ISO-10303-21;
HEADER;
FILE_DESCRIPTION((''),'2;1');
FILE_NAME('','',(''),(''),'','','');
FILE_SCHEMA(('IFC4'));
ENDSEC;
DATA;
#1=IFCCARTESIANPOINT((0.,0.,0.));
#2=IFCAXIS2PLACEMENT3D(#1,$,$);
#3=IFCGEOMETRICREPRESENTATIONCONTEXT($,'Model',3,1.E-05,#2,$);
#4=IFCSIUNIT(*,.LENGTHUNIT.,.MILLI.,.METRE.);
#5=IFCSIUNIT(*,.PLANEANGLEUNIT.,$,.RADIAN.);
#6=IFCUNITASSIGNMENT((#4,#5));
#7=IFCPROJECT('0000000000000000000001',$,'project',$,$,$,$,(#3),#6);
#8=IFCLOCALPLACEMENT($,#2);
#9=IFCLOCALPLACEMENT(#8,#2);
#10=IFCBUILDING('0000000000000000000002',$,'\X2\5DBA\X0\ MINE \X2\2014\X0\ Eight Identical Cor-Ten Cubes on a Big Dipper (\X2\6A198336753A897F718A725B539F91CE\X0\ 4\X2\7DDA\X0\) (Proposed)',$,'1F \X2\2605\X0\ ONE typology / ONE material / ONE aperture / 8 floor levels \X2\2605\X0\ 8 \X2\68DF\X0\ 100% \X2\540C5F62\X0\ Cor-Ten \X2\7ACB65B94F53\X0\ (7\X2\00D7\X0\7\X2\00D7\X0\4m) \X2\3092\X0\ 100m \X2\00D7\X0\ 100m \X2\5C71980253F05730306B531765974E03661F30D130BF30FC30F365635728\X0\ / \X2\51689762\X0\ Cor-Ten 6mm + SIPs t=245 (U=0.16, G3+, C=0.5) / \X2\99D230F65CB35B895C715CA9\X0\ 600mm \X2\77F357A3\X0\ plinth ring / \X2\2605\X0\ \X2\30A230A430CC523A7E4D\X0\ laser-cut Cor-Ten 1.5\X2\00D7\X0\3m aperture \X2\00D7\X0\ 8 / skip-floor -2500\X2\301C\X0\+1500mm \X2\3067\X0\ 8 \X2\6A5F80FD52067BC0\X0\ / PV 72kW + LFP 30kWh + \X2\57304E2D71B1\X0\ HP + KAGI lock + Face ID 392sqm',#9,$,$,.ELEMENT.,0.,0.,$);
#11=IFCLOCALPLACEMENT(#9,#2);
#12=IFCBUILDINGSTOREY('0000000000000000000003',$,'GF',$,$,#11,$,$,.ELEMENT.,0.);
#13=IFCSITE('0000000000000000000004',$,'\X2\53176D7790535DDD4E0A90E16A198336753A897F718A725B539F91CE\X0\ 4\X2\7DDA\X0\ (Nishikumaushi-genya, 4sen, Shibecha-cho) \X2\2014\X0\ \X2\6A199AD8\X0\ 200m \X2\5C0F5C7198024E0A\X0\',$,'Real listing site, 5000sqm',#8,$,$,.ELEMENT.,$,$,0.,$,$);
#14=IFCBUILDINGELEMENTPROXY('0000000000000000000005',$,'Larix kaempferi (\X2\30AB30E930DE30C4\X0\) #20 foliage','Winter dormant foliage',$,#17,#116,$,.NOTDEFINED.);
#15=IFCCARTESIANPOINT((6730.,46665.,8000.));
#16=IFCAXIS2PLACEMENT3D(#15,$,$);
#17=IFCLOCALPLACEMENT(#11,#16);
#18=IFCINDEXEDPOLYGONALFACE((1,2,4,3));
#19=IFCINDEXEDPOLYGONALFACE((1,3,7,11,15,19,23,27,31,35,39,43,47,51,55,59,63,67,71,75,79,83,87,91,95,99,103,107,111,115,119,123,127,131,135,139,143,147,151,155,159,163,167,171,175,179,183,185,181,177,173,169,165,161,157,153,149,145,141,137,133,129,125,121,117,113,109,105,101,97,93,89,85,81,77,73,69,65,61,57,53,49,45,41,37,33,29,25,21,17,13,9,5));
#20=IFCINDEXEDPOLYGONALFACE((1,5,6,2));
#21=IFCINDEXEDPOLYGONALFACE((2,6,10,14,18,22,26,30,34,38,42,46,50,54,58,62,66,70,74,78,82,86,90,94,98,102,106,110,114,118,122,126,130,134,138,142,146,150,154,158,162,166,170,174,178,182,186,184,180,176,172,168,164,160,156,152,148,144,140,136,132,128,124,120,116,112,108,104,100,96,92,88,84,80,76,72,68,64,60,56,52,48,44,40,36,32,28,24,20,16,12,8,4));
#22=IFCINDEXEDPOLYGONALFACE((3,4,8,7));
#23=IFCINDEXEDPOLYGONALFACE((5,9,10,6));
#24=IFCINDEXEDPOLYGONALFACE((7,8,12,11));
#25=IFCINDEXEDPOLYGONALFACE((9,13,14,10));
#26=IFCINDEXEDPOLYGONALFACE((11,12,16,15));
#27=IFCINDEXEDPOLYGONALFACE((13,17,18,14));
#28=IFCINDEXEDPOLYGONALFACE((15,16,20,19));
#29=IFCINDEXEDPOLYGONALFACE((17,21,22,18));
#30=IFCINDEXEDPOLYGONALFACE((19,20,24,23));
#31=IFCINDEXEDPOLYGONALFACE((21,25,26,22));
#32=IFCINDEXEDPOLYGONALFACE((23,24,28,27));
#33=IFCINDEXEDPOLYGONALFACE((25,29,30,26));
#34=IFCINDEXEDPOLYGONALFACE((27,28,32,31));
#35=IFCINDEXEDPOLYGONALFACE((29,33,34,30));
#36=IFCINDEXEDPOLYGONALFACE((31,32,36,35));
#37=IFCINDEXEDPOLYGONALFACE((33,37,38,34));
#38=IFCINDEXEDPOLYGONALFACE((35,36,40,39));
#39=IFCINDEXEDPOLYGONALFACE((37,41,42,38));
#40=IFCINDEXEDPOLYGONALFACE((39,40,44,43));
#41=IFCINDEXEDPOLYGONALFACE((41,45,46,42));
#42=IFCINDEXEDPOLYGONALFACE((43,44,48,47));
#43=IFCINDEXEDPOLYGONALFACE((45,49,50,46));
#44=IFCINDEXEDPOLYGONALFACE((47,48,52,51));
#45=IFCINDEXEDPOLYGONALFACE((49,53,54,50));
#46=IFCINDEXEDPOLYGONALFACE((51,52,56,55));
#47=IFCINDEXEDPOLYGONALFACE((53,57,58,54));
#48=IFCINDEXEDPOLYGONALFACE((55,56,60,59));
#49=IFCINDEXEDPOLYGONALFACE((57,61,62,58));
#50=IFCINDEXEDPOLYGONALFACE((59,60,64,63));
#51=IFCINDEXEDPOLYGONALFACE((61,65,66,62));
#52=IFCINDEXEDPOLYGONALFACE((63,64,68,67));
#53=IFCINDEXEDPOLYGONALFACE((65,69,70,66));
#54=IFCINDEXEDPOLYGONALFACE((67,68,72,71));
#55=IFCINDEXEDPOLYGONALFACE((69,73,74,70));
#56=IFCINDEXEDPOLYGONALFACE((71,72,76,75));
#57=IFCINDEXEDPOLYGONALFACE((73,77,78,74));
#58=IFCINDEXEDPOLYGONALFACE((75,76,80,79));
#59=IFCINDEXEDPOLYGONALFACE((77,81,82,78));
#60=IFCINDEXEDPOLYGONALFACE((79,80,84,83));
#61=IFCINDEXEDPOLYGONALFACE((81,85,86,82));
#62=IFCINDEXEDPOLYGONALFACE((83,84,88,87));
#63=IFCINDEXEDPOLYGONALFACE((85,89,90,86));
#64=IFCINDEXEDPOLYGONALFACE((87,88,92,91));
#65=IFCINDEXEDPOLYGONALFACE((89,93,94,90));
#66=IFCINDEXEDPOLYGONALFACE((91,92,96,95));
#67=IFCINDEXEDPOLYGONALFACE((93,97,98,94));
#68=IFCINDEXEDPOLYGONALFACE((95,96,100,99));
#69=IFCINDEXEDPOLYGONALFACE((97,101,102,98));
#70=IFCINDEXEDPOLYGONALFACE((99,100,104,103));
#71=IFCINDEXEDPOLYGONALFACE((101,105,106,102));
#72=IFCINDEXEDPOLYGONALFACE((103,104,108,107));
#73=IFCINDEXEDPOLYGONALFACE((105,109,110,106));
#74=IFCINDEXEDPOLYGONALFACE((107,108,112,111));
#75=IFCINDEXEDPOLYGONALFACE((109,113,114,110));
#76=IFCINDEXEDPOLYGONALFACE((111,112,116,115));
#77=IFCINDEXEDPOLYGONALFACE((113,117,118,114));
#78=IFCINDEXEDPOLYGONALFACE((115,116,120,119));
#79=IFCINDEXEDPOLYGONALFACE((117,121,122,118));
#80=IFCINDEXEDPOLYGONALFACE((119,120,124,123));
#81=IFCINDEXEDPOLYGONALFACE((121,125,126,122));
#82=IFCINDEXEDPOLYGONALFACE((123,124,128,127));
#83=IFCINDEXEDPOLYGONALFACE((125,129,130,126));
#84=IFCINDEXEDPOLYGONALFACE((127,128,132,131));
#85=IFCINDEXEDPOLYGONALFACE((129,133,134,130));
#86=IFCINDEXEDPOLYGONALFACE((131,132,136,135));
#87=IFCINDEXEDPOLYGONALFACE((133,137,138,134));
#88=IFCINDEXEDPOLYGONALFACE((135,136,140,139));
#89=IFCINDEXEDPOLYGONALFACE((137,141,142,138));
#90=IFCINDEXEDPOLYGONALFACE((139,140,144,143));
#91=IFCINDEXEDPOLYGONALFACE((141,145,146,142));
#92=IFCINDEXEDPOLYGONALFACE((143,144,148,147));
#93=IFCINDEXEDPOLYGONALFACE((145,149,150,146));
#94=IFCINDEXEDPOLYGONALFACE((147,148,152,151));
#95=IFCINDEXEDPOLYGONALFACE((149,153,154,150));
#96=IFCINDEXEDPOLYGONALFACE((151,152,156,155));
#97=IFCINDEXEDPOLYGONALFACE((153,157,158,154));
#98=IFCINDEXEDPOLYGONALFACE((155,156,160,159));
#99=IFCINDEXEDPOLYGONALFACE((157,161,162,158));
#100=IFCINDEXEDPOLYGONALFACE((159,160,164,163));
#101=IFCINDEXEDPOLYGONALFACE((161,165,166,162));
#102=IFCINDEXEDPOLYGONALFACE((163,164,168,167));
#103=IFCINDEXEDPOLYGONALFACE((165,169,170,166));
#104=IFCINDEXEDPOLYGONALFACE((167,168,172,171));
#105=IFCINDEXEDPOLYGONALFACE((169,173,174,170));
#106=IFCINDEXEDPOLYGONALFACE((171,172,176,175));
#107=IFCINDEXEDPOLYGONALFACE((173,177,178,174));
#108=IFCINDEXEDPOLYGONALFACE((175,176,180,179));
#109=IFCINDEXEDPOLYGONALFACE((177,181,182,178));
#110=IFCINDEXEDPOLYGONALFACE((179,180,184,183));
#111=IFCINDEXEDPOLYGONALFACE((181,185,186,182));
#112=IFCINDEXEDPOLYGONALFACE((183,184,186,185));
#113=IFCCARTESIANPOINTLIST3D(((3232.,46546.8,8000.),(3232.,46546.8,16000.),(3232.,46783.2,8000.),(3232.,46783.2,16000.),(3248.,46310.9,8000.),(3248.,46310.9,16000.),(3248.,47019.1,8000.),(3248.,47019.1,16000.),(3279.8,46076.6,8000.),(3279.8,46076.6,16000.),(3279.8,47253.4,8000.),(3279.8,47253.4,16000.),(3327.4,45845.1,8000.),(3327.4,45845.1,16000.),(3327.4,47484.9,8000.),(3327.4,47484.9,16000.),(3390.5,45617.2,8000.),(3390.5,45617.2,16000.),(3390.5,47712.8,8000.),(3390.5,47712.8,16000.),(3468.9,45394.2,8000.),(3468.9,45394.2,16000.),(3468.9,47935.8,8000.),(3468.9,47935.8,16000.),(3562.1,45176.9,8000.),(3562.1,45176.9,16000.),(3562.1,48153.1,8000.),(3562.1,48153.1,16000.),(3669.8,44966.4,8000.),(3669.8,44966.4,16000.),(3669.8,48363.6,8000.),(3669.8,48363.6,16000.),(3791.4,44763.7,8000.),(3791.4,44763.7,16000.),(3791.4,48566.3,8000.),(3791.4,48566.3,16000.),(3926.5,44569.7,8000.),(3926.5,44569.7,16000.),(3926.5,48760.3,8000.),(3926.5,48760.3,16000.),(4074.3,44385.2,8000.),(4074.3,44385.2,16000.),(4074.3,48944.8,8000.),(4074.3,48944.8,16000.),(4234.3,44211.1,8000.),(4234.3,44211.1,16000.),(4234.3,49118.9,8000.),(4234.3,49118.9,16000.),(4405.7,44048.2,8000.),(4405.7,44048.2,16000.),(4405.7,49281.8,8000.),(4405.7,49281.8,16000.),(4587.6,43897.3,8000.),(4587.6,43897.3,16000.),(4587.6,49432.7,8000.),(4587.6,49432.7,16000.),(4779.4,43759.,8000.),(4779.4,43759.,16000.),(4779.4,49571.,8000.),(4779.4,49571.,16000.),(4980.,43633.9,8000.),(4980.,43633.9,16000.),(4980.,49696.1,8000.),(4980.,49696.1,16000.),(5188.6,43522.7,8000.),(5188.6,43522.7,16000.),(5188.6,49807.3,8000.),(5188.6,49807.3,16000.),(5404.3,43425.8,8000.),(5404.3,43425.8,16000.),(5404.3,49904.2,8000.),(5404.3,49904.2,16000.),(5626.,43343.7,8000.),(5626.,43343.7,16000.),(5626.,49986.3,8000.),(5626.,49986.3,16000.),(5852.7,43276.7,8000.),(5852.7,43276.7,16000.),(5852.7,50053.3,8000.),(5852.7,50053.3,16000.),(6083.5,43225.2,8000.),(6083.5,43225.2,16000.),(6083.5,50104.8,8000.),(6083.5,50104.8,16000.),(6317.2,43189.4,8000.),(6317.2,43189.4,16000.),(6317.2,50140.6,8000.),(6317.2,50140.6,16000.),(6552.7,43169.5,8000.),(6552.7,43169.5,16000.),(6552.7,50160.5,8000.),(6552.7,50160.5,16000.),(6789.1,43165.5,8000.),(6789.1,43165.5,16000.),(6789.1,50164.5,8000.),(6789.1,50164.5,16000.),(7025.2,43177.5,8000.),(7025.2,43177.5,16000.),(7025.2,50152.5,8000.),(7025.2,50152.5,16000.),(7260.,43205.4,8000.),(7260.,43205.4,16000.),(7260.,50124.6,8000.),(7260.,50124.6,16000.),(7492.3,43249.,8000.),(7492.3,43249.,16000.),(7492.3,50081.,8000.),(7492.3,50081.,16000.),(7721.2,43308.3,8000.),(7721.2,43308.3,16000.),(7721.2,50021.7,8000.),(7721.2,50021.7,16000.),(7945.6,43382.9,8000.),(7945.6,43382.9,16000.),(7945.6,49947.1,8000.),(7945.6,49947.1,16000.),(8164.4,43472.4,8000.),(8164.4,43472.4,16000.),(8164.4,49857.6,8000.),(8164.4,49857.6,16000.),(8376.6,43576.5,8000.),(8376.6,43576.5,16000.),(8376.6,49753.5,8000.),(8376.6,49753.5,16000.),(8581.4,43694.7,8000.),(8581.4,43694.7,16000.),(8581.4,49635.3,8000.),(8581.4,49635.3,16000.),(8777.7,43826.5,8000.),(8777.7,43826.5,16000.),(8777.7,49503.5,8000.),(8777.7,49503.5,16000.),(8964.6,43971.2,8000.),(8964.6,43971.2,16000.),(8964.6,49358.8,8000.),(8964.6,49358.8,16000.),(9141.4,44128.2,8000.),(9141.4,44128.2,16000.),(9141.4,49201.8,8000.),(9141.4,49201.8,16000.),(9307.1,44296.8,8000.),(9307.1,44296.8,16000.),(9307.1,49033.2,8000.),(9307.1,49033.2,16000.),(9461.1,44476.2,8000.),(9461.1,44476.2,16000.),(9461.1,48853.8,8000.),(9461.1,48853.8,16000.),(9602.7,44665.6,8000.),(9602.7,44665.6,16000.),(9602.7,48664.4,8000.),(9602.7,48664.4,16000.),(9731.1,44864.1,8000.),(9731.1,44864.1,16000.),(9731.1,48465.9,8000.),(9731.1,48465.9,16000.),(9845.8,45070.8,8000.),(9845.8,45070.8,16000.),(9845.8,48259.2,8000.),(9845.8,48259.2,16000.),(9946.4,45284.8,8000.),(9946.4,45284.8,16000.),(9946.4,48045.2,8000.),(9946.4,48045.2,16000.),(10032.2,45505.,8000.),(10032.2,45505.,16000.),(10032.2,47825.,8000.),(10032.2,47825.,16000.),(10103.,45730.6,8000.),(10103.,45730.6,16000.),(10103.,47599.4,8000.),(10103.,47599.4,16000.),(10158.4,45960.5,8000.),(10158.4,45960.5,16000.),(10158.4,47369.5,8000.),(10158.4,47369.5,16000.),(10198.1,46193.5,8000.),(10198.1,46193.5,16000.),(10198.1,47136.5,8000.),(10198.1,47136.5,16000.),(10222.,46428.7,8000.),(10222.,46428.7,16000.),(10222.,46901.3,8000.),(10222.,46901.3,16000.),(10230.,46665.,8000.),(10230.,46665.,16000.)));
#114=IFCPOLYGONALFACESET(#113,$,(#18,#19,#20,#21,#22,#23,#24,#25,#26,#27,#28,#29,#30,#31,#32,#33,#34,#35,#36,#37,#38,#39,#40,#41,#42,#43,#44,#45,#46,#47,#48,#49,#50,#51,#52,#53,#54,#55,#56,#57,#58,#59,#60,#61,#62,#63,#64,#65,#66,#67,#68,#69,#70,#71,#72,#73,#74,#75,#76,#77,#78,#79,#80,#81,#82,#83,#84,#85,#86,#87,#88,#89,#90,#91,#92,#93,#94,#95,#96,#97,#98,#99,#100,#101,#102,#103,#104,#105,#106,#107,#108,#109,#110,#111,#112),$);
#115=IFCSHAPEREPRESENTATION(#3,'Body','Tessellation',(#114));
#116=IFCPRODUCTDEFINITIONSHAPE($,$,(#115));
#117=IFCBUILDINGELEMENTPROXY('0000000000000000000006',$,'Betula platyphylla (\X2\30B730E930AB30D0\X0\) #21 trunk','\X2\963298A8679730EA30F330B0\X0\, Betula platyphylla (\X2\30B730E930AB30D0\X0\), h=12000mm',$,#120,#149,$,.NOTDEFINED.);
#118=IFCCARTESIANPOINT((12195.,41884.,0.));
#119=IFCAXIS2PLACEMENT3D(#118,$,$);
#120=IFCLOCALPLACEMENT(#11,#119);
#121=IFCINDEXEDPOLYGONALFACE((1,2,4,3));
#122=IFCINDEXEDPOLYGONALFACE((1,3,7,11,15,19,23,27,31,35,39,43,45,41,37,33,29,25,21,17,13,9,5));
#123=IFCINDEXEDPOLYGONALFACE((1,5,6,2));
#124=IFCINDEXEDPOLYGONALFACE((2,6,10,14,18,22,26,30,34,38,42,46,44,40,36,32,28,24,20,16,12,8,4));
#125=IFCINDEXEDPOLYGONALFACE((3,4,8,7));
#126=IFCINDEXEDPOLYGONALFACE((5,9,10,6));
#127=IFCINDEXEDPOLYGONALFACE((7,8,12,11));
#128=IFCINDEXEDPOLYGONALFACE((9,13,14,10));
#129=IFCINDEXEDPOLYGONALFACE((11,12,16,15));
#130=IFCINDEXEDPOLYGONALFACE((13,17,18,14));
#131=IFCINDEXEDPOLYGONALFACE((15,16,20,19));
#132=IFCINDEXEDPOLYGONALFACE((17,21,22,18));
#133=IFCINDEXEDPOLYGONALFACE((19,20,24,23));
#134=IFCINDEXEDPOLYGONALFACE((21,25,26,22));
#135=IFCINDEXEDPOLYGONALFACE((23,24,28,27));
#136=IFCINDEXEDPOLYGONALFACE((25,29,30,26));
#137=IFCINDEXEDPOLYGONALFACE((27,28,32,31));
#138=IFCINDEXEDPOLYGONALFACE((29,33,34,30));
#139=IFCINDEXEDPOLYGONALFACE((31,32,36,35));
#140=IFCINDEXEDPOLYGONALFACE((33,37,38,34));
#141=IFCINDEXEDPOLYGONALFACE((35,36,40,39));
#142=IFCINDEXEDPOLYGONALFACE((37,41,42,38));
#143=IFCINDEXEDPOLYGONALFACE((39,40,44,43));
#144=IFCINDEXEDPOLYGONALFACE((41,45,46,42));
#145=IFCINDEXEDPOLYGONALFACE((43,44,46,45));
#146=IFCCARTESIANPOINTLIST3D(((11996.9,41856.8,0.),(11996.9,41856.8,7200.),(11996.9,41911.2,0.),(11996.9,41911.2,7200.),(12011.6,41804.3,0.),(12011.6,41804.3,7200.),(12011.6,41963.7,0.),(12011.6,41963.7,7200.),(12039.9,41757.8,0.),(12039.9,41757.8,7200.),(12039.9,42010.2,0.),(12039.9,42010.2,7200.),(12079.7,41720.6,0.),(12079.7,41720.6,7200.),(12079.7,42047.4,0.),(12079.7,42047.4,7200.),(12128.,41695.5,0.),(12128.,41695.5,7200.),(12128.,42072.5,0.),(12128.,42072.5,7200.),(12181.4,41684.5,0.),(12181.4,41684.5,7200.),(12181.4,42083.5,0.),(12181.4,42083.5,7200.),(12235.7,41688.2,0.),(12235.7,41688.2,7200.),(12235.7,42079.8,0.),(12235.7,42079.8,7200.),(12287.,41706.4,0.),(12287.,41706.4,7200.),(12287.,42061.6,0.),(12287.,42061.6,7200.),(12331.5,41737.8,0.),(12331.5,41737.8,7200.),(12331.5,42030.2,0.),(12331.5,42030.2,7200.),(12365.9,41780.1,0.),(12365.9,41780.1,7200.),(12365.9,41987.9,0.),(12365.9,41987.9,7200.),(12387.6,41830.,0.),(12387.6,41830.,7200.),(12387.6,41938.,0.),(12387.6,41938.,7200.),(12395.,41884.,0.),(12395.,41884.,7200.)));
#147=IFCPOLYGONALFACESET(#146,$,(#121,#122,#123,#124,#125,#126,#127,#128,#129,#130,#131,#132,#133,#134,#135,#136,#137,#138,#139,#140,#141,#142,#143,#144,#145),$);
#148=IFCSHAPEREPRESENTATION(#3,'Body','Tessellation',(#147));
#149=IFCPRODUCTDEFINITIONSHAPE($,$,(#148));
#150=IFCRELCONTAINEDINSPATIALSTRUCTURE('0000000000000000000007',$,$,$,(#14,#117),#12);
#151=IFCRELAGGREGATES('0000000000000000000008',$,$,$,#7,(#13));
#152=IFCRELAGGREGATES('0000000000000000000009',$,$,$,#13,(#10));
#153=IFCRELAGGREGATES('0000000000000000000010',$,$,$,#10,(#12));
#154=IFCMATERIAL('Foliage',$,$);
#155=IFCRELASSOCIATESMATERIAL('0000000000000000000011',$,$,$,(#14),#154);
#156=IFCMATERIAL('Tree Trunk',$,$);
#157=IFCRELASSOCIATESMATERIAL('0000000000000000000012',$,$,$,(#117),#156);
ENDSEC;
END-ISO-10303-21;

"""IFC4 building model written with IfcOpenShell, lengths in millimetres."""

from ifc_helpers import new_model, si_unit, frame, origin, origin_2d, place, context, project, spatial, circle, extrude, material, element, save


model = new_model("IFC4")

# Units and contexts
model_context = context("Model", 3, precision=1e-05, world=origin())
ifc_project = project(units=[si_unit("LENGTHUNIT", "METRE", prefix="MILLI"), si_unit("PLANEANGLEUNIT", "RADIAN")], contexts=[model_context])

# Site, building, storey
site_placement = place(None, origin())
site = spatial("IfcSite", under=ifc_project, at=site_placement, Name="北海道川上郡標茶町西熊牛原野 4線 (Nishikumaushi-genya, 4sen, Shibecha-cho) — 標高 200m 小山頂上", ObjectType="Real listing site, 5000sqm", CompositionType="ELEMENT", RefElevation=0.0)
building_placement = place(site_placement, origin())
building = spatial("IfcBuilding", under=site, at=building_placement, Name="嶺 MINE — Eight Identical Cor-Ten Cubes on a Big Dipper (標茶町西熊牛原野 4線) (Proposed)", ObjectType="1F ★ ONE typology / ONE material / ONE aperture / 8 floor levels ★ 8 棟 100% 同形 Cor-Ten 立方体 (7×7×4m) を 100m × 100m 山頂台地に北斗七星パターン散在 / 全面 Cor-Ten 6mm + SIPs t=245 (U=0.16, G3+, C=0.5) / 駒ヶ岳安山岩 600mm 石垣 plinth ring / ★ アイヌ刺繍 laser-cut Cor-Ten 1.5×3m aperture × 8 / skip-floor -2500〜+1500mm で 8 機能分節 / PV 72kW + LFP 30kWh + 地中熱 HP + KAGI lock + Face ID 392sqm", CompositionType="ELEMENT", ElevationOfRefHeight=0.0, ElevationOfTerrain=0.0)
storey_placement = place(building_placement, origin())
storey = spatial("IfcBuildingStorey", under=building, at=storey_placement, Name="GF", CompositionType="ELEMENT", Elevation=0.0)

# Building element proxies
ifc_material_1 = material(Name="Tree Trunk")
ifc_material_2 = material(Name="Foliage")
proxy_1_placement = place(storey_placement, frame((6730.0, 46665.0, 8000.0)))
element("IfcBuildingElementProxy", 1, at=proxy_1_placement, inside=storey, material=ifc_material_2, Name="Larix kaempferi (カラマツ) #20 foliage", Description="Winter dormant foliage", PredefinedType="NOTDEFINED", context=model_context, shape_type="SweptSolid", body=[
    extrude(circle(Radius=3500.0, at=origin_2d()), frame((6730.0, 46665.0, 8000.0)), (0.0, 0.0, 1.0), 8000.0),
])
proxy_2_placement = place(storey_placement, frame((12195.0, 41884.0, 0.0)))
element("IfcBuildingElementProxy", 2, at=proxy_2_placement, inside=storey, material=ifc_material_1, Name="Betula platyphylla (シラカバ) #21 trunk", Description="防風林リング, Betula platyphylla (シラカバ), h=12000mm", PredefinedType="NOTDEFINED", context=model_context, shape_type="SweptSolid", body=[
    extrude(circle(Radius=200.0, at=origin_2d()), frame((12195.0, 41884.0, 0.0)), (0.0, 0.0, 1.0), 7200.0),
])

save(model, "model.ifc")
